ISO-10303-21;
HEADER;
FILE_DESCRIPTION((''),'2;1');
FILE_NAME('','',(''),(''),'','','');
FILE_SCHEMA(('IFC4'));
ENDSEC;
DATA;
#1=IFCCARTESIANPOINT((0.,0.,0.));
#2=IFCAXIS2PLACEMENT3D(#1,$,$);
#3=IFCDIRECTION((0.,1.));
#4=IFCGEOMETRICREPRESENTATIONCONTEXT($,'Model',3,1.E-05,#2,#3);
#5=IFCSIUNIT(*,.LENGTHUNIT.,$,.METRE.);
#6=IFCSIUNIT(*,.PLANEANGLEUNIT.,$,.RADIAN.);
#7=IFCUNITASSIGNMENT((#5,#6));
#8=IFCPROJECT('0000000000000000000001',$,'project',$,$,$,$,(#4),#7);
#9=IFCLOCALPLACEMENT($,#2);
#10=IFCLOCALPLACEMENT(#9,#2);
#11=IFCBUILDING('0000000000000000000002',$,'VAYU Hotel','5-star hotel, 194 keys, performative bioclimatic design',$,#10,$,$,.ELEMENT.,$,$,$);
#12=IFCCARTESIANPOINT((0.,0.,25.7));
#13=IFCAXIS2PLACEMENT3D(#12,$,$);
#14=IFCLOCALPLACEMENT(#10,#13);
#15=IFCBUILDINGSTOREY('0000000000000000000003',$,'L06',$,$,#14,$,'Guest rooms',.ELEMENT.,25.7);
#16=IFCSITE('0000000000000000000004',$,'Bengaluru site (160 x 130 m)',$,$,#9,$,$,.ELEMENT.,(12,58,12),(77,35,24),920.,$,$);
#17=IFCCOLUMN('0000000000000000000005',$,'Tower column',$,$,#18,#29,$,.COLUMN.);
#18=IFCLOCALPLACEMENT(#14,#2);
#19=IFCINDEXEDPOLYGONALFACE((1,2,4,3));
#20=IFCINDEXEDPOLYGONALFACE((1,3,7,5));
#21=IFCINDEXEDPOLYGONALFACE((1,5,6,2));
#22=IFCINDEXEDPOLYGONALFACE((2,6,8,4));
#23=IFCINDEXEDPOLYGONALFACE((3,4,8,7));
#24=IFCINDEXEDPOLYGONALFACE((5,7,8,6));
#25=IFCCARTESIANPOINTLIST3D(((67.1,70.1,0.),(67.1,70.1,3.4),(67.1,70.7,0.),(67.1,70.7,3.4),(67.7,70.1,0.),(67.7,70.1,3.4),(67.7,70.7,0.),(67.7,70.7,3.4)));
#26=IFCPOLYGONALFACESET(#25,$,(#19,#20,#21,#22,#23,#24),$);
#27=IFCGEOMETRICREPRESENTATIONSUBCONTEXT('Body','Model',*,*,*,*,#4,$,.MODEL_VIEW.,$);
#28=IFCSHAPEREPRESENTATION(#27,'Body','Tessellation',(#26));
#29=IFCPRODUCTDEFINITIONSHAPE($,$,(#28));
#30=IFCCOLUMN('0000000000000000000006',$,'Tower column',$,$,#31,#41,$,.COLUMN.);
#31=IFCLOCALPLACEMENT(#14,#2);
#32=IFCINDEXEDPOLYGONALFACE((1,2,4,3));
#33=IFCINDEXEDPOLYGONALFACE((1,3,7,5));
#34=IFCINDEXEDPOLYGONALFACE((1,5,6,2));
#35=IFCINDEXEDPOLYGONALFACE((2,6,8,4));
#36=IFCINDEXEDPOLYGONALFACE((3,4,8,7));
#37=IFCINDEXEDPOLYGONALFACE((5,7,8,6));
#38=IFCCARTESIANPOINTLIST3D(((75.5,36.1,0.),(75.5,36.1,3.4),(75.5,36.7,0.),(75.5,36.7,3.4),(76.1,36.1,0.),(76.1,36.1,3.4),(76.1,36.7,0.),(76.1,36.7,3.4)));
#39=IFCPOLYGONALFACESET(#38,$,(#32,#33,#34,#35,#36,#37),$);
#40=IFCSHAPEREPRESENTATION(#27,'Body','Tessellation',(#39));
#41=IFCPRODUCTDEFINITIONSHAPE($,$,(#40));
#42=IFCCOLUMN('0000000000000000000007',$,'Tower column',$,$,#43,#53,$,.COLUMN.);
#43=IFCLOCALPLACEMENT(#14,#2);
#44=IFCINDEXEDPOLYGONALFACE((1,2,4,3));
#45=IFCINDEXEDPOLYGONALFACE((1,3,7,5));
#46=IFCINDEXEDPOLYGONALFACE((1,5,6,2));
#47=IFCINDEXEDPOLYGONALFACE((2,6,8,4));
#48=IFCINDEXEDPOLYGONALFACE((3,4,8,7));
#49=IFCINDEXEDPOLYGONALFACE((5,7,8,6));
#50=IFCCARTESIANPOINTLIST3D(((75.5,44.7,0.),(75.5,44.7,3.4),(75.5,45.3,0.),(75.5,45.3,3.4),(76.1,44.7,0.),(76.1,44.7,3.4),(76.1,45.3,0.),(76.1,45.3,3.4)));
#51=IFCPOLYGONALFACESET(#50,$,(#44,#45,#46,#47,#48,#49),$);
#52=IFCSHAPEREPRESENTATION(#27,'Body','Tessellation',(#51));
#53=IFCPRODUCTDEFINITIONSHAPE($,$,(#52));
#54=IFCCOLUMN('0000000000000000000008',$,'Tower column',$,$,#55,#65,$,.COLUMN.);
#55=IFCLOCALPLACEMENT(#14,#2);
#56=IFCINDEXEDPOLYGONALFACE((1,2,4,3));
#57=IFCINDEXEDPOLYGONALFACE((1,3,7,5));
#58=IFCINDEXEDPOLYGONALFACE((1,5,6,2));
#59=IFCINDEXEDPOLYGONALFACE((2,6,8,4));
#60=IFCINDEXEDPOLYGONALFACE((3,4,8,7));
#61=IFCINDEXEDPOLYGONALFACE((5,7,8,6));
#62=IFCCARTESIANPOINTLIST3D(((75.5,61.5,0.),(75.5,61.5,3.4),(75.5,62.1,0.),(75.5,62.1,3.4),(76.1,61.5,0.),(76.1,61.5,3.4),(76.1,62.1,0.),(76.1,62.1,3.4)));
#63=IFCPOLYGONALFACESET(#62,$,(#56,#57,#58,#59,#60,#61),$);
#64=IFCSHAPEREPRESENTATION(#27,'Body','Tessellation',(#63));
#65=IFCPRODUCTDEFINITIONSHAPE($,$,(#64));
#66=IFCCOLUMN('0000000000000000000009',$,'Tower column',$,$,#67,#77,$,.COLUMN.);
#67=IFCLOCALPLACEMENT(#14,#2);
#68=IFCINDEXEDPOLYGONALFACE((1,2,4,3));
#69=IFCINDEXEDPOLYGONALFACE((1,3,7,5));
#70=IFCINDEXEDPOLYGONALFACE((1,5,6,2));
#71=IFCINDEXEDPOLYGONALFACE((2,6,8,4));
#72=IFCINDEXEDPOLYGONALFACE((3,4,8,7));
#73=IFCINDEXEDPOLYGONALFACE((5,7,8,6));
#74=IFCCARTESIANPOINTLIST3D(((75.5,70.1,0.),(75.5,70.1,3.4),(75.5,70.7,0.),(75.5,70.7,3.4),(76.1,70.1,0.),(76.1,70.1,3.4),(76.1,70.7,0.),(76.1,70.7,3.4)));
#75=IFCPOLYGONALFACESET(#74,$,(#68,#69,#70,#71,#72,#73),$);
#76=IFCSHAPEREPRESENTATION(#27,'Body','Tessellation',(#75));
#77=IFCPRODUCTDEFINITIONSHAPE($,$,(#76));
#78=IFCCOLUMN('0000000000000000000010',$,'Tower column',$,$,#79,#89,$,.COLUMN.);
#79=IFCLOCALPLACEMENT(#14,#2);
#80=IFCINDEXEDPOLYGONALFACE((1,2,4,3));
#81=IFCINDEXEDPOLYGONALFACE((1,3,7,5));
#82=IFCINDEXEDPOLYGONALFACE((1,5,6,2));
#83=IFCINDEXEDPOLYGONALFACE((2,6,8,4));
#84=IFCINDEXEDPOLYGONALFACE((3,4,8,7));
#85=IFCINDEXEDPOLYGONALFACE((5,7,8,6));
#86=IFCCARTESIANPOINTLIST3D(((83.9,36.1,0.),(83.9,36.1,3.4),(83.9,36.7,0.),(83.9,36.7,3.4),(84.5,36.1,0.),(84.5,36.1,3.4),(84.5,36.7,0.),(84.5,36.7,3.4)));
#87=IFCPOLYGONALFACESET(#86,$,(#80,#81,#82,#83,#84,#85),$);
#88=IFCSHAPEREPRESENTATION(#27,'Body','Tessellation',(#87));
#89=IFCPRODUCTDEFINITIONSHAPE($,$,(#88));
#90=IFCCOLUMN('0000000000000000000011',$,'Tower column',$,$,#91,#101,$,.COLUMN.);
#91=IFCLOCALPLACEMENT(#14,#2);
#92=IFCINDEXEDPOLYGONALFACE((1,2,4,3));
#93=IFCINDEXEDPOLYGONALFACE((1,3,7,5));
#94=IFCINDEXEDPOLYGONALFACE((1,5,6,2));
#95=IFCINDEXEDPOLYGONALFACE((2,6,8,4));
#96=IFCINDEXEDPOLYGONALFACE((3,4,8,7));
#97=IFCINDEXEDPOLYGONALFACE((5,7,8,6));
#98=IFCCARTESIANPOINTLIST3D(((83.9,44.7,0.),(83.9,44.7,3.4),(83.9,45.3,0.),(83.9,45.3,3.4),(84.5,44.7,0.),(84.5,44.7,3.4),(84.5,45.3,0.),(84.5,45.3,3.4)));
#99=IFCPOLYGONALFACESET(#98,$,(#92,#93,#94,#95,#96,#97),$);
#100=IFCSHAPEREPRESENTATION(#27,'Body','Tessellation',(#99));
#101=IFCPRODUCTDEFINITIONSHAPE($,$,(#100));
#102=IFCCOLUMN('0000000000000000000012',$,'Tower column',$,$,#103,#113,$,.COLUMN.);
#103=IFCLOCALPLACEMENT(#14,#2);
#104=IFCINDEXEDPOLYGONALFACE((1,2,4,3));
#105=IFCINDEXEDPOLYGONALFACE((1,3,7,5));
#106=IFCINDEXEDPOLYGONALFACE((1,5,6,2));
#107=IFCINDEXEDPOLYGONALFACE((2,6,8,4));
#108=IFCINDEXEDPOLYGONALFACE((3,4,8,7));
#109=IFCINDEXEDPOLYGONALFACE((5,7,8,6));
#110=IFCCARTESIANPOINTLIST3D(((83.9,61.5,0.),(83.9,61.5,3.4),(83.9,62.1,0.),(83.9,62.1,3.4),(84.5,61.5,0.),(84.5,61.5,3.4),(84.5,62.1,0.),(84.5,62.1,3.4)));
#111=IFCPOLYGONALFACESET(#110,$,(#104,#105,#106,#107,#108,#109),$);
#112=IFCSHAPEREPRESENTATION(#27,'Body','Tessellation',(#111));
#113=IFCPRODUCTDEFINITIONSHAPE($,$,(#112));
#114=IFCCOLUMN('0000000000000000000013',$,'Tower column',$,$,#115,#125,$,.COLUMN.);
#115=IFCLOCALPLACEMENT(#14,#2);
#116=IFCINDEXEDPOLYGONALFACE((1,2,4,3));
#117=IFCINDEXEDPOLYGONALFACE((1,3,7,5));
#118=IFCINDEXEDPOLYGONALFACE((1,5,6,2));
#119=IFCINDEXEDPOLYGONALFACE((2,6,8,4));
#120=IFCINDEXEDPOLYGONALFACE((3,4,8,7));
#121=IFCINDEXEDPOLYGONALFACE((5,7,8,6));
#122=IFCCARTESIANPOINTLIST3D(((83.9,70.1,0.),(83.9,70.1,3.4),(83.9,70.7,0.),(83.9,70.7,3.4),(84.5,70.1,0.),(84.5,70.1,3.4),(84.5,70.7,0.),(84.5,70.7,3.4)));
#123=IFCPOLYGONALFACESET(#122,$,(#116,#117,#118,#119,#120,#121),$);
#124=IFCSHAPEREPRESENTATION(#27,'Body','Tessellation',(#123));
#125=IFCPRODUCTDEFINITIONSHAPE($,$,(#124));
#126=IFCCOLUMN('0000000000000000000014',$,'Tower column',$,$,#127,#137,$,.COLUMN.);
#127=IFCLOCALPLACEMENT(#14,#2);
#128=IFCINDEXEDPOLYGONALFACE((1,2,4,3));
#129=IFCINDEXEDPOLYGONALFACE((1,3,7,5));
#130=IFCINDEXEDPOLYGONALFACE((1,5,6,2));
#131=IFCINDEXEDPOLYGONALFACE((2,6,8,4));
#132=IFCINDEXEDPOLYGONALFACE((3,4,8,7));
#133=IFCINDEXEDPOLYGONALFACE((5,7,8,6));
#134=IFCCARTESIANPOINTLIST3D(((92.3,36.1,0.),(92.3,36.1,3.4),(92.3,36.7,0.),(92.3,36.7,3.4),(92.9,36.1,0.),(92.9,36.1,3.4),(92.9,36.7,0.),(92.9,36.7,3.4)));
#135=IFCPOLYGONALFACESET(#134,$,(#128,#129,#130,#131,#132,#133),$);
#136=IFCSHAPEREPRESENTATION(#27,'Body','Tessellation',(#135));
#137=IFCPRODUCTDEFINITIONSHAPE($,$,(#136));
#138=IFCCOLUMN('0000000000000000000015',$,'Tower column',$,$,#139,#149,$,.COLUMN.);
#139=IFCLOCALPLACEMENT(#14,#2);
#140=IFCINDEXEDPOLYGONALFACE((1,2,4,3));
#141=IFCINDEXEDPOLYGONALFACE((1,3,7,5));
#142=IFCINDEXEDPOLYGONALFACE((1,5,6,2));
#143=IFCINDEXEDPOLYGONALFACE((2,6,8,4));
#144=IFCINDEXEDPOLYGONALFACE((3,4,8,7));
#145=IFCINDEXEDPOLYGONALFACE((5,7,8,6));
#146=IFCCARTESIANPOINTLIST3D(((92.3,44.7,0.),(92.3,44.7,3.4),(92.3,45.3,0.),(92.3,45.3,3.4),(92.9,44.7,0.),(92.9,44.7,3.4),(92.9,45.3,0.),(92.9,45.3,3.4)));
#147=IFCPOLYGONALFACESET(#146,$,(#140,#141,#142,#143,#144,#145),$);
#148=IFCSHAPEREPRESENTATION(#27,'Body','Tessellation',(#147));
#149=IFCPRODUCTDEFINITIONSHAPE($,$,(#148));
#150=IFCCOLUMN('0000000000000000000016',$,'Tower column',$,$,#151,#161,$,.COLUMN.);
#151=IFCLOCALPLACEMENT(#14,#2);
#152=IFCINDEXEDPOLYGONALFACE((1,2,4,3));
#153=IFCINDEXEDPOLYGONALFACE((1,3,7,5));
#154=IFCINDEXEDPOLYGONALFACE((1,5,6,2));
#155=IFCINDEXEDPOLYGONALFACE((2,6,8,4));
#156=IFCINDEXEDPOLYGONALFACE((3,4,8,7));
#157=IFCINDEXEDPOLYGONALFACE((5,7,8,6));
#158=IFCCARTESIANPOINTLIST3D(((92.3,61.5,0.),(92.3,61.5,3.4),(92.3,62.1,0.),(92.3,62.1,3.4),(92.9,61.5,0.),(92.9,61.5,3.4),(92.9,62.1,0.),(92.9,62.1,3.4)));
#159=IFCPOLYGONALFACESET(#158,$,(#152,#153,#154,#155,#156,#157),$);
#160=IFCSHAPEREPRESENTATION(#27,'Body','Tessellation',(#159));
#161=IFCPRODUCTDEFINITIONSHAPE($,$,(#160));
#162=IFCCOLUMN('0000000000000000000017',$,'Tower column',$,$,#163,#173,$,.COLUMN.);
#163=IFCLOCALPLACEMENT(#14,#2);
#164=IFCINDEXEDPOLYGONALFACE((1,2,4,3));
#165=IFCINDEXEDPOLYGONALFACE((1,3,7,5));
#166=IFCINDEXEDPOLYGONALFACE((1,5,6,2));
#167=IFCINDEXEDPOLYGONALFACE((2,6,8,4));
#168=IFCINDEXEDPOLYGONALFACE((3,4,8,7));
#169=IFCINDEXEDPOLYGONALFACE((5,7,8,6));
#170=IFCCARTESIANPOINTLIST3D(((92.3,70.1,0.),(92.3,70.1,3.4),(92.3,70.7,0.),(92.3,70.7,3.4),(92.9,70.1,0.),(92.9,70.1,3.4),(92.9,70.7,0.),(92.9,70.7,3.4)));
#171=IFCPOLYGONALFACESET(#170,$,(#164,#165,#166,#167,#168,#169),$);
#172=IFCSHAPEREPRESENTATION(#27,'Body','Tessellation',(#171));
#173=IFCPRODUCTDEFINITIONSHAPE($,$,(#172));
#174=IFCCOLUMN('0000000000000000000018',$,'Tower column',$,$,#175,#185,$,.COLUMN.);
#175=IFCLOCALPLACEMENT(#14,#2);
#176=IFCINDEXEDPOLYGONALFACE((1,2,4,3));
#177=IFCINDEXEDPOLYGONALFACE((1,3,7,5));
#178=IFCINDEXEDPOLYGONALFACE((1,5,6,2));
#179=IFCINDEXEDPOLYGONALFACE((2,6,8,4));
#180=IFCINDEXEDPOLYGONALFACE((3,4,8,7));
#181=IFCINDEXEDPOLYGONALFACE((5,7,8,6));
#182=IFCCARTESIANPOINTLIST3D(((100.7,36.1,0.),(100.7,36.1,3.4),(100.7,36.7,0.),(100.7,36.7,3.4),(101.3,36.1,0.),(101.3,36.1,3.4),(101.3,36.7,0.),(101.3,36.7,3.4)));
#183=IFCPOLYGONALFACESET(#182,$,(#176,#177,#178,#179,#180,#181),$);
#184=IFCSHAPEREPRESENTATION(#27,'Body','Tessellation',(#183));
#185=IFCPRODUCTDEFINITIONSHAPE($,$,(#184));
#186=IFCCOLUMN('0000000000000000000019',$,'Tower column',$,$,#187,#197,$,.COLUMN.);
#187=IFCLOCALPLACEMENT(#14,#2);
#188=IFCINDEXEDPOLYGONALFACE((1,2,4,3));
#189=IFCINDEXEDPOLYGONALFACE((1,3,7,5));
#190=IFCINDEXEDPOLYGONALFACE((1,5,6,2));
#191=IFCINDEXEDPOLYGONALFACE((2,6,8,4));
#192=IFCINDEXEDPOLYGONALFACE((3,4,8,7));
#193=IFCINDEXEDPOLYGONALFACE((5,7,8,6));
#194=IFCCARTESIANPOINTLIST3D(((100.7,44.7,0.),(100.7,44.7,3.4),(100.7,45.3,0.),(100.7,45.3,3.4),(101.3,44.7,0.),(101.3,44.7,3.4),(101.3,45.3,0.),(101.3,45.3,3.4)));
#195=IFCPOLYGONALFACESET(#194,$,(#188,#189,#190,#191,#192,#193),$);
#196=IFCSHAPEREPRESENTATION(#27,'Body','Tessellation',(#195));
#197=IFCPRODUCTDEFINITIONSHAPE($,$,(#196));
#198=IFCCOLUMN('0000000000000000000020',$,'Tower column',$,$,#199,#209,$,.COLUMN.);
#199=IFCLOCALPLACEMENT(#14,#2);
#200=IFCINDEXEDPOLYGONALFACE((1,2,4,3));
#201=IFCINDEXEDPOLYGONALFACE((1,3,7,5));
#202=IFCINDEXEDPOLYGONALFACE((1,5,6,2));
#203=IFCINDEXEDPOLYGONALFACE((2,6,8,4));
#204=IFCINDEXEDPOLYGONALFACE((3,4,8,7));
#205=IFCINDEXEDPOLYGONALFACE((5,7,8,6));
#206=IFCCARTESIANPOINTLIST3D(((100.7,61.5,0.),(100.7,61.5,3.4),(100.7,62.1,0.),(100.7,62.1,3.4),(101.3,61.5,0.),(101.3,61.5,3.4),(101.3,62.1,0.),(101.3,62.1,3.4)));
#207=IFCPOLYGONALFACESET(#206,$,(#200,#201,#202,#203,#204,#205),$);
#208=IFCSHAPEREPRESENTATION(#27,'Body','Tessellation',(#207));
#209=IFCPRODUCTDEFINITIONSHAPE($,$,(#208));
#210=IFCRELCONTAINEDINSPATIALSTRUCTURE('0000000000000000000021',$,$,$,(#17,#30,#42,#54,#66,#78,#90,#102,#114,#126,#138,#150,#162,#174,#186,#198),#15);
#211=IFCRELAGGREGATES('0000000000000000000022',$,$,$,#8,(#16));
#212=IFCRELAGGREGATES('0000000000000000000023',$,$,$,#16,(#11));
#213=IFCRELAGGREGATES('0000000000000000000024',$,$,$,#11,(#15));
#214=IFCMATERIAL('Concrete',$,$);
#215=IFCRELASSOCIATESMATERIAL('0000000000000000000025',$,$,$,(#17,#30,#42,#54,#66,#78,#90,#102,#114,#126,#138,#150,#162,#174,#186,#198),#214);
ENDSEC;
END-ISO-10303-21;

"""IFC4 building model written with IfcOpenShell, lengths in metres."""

from ifc_helpers import new_model, si_unit, direction, frame, origin, place, context, subcontext, project, spatial, polyline, outline, extrude, material, element, save


model = new_model("IFC4")

# Units and contexts
model_context = context("Model", 3, precision=1e-05, world=origin(), true_north=direction((0.0, 1.0)))
body_context = subcontext(model_context, "Body", "Model", "MODEL_VIEW")
ifc_project = project(units=[si_unit("LENGTHUNIT", "METRE"), si_unit("PLANEANGLEUNIT", "RADIAN")], contexts=[model_context])

# Site, building, storey
site_placement = place(None, origin())
site = spatial("IfcSite", under=ifc_project, at=site_placement, Name="Bengaluru site (160 x 130 m)", CompositionType="ELEMENT", RefLatitude=(12, 58, 12), RefLongitude=(77, 35, 24), RefElevation=920.0)
building_placement = place(site_placement, origin())
building = spatial("IfcBuilding", under=site, at=building_placement, Name="VAYU Hotel", Description="5-star hotel, 194 keys, performative bioclimatic design", CompositionType="ELEMENT")
storey_placement = place(building_placement, frame((0.0, 0.0, 25.7)))
storey = spatial("IfcBuildingStorey", under=building, at=storey_placement, Name="L06", LongName="Guest rooms", CompositionType="ELEMENT", Elevation=25.7)

# Columns
ifc_material = material(Name="Concrete")
column_1_placement = place(storey_placement, origin())
element("IfcColumn", 1, at=column_1_placement, inside=storey, material=ifc_material, Name="Tower column", PredefinedType="COLUMN", context=body_context, shape_type="SweptSolid", body=[
    extrude(outline(polyline([(67.1, 70.1), (67.7, 70.1), (67.7, 70.7), (67.1, 70.7), (67.1, 70.1)])), origin(), (0.0, 0.0, 1.0), 3.4),
])
column_2_placement = place(storey_placement, origin())
element("IfcColumn", 2, at=column_2_placement, inside=storey, material=ifc_material, Name="Tower column", PredefinedType="COLUMN", context=body_context, shape_type="SweptSolid", body=[
    extrude(outline(polyline([(75.5, 36.1), (76.1, 36.1), (76.1, 36.7), (75.5, 36.7), (75.5, 36.1)])), origin(), (0.0, 0.0, 1.0), 3.4),
])
column_3_placement = place(storey_placement, origin())
element("IfcColumn", 3, at=column_3_placement, inside=storey, material=ifc_material, Name="Tower column", PredefinedType="COLUMN", context=body_context, shape_type="SweptSolid", body=[
    extrude(outline(polyline([(75.5, 44.7), (76.1, 44.7), (76.1, 45.3), (75.5, 45.3), (75.5, 44.7)])), origin(), (0.0, 0.0, 1.0), 3.4),
])
column_4_placement = place(storey_placement, origin())
element("IfcColumn", 4, at=column_4_placement, inside=storey, material=ifc_material, Name="Tower column", PredefinedType="COLUMN", context=body_context, shape_type="SweptSolid", body=[
    extrude(outline(polyline([(75.5, 61.5), (76.1, 61.5), (76.1, 62.1), (75.5, 62.1), (75.5, 61.5)])), origin(), (0.0, 0.0, 1.0), 3.4),
])
column_5_placement = place(storey_placement, origin())
element("IfcColumn", 5, at=column_5_placement, inside=storey, material=ifc_material, Name="Tower column", PredefinedType="COLUMN", context=body_context, shape_type="SweptSolid", body=[
    extrude(outline(polyline([(75.5, 70.1), (76.1, 70.1), (76.1, 70.7), (75.5, 70.7), (75.5, 70.1)])), origin(), (0.0, 0.0, 1.0), 3.4),
])
column_6_placement = place(storey_placement, origin())
element("IfcColumn", 6, at=column_6_placement, inside=storey, material=ifc_material, Name="Tower column", PredefinedType="COLUMN", context=body_context, shape_type="SweptSolid", body=[
    extrude(outline(polyline([(83.9, 36.1), (84.5, 36.1), (84.5, 36.7), (83.9, 36.7), (83.9, 36.1)])), origin(), (0.0, 0.0, 1.0), 3.4),
])
column_7_placement = place(storey_placement, origin())
element("IfcColumn", 7, at=column_7_placement, inside=storey, material=ifc_material, Name="Tower column", PredefinedType="COLUMN", context=body_context, shape_type="SweptSolid", body=[
    extrude(outline(polyline([(83.9, 44.7), (84.5, 44.7), (84.5, 45.3), (83.9, 45.3), (83.9, 44.7)])), origin(), (0.0, 0.0, 1.0), 3.4),
])
column_8_placement = place(storey_placement, origin())
element("IfcColumn", 8, at=column_8_placement, inside=storey, material=ifc_material, Name="Tower column", PredefinedType="COLUMN", context=body_context, shape_type="SweptSolid", body=[
    extrude(outline(polyline([(83.9, 61.5), (84.5, 61.5), (84.5, 62.1), (83.9, 62.1), (83.9, 61.5)])), origin(), (0.0, 0.0, 1.0), 3.4),
])
column_9_placement = place(storey_placement, origin())
element("IfcColumn", 9, at=column_9_placement, inside=storey, material=ifc_material, Name="Tower column", PredefinedType="COLUMN", context=body_context, shape_type="SweptSolid", body=[
    extrude(outline(polyline([(83.9, 70.1), (84.5, 70.1), (84.5, 70.7), (83.9, 70.7), (83.9, 70.1)])), origin(), (0.0, 0.0, 1.0), 3.4),
])
column_10_placement = place(storey_placement, origin())
element("IfcColumn", 10, at=column_10_placement, inside=storey, material=ifc_material, Name="Tower column", PredefinedType="COLUMN", context=body_context, shape_type="SweptSolid", body=[
    extrude(outline(polyline([(92.3, 36.1), (92.9, 36.1), (92.9, 36.7), (92.3, 36.7), (92.3, 36.1)])), origin(), (0.0, 0.0, 1.0), 3.4),
])
column_11_placement = place(storey_placement, origin())
element("IfcColumn", 11, at=column_11_placement, inside=storey, material=ifc_material, Name="Tower column", PredefinedType="COLUMN", context=body_context, shape_type="SweptSolid", body=[
    extrude(outline(polyline([(92.3, 44.7), (92.9, 44.7), (92.9, 45.3), (92.3, 45.3), (92.3, 44.7)])), origin(), (0.0, 0.0, 1.0), 3.4),
])
column_12_placement = place(storey_placement, origin())
element("IfcColumn", 12, at=column_12_placement, inside=storey, material=ifc_material, Name="Tower column", PredefinedType="COLUMN", context=body_context, shape_type="SweptSolid", body=[
    extrude(outline(polyline([(92.3, 61.5), (92.9, 61.5), (92.9, 62.1), (92.3, 62.1), (92.3, 61.5)])), origin(), (0.0, 0.0, 1.0), 3.4),
])
column_13_placement = place(storey_placement, origin())
element("IfcColumn", 13, at=column_13_placement, inside=storey, material=ifc_material, Name="Tower column", PredefinedType="COLUMN", context=body_context, shape_type="SweptSolid", body=[
    extrude(outline(polyline([(92.3, 70.1), (92.9, 70.1), (92.9, 70.7), (92.3, 70.7), (92.3, 70.1)])), origin(), (0.0, 0.0, 1.0), 3.4),
])
column_14_placement = place(storey_placement, origin())
element("IfcColumn", 14, at=column_14_placement, inside=storey, material=ifc_material, Name="Tower column", PredefinedType="COLUMN", context=body_context, shape_type="SweptSolid", body=[
    extrude(outline(polyline([(100.7, 36.1), (101.3, 36.1), (101.3, 36.7), (100.7, 36.7), (100.7, 36.1)])), origin(), (0.0, 0.0, 1.0), 3.4),
])
column_15_placement = place(storey_placement, origin())
element("IfcColumn", 15, at=column_15_placement, inside=storey, material=ifc_material, Name="Tower column", PredefinedType="COLUMN", context=body_context, shape_type="SweptSolid", body=[
    extrude(outline(polyline([(100.7, 44.7), (101.3, 44.7), (101.3, 45.3), (100.7, 45.3), (100.7, 44.7)])), origin(), (0.0, 0.0, 1.0), 3.4),
])
column_16_placement = place(storey_placement, origin())
element("IfcColumn", 16, at=column_16_placement, inside=storey, material=ifc_material, Name="Tower column", PredefinedType="COLUMN", context=body_context, shape_type="SweptSolid", body=[
    extrude(outline(polyline([(100.7, 61.5), (101.3, 61.5), (101.3, 62.1), (100.7, 62.1), (100.7, 61.5)])), origin(), (0.0, 0.0, 1.0), 3.4),
])

save(model, "model.ifc")
